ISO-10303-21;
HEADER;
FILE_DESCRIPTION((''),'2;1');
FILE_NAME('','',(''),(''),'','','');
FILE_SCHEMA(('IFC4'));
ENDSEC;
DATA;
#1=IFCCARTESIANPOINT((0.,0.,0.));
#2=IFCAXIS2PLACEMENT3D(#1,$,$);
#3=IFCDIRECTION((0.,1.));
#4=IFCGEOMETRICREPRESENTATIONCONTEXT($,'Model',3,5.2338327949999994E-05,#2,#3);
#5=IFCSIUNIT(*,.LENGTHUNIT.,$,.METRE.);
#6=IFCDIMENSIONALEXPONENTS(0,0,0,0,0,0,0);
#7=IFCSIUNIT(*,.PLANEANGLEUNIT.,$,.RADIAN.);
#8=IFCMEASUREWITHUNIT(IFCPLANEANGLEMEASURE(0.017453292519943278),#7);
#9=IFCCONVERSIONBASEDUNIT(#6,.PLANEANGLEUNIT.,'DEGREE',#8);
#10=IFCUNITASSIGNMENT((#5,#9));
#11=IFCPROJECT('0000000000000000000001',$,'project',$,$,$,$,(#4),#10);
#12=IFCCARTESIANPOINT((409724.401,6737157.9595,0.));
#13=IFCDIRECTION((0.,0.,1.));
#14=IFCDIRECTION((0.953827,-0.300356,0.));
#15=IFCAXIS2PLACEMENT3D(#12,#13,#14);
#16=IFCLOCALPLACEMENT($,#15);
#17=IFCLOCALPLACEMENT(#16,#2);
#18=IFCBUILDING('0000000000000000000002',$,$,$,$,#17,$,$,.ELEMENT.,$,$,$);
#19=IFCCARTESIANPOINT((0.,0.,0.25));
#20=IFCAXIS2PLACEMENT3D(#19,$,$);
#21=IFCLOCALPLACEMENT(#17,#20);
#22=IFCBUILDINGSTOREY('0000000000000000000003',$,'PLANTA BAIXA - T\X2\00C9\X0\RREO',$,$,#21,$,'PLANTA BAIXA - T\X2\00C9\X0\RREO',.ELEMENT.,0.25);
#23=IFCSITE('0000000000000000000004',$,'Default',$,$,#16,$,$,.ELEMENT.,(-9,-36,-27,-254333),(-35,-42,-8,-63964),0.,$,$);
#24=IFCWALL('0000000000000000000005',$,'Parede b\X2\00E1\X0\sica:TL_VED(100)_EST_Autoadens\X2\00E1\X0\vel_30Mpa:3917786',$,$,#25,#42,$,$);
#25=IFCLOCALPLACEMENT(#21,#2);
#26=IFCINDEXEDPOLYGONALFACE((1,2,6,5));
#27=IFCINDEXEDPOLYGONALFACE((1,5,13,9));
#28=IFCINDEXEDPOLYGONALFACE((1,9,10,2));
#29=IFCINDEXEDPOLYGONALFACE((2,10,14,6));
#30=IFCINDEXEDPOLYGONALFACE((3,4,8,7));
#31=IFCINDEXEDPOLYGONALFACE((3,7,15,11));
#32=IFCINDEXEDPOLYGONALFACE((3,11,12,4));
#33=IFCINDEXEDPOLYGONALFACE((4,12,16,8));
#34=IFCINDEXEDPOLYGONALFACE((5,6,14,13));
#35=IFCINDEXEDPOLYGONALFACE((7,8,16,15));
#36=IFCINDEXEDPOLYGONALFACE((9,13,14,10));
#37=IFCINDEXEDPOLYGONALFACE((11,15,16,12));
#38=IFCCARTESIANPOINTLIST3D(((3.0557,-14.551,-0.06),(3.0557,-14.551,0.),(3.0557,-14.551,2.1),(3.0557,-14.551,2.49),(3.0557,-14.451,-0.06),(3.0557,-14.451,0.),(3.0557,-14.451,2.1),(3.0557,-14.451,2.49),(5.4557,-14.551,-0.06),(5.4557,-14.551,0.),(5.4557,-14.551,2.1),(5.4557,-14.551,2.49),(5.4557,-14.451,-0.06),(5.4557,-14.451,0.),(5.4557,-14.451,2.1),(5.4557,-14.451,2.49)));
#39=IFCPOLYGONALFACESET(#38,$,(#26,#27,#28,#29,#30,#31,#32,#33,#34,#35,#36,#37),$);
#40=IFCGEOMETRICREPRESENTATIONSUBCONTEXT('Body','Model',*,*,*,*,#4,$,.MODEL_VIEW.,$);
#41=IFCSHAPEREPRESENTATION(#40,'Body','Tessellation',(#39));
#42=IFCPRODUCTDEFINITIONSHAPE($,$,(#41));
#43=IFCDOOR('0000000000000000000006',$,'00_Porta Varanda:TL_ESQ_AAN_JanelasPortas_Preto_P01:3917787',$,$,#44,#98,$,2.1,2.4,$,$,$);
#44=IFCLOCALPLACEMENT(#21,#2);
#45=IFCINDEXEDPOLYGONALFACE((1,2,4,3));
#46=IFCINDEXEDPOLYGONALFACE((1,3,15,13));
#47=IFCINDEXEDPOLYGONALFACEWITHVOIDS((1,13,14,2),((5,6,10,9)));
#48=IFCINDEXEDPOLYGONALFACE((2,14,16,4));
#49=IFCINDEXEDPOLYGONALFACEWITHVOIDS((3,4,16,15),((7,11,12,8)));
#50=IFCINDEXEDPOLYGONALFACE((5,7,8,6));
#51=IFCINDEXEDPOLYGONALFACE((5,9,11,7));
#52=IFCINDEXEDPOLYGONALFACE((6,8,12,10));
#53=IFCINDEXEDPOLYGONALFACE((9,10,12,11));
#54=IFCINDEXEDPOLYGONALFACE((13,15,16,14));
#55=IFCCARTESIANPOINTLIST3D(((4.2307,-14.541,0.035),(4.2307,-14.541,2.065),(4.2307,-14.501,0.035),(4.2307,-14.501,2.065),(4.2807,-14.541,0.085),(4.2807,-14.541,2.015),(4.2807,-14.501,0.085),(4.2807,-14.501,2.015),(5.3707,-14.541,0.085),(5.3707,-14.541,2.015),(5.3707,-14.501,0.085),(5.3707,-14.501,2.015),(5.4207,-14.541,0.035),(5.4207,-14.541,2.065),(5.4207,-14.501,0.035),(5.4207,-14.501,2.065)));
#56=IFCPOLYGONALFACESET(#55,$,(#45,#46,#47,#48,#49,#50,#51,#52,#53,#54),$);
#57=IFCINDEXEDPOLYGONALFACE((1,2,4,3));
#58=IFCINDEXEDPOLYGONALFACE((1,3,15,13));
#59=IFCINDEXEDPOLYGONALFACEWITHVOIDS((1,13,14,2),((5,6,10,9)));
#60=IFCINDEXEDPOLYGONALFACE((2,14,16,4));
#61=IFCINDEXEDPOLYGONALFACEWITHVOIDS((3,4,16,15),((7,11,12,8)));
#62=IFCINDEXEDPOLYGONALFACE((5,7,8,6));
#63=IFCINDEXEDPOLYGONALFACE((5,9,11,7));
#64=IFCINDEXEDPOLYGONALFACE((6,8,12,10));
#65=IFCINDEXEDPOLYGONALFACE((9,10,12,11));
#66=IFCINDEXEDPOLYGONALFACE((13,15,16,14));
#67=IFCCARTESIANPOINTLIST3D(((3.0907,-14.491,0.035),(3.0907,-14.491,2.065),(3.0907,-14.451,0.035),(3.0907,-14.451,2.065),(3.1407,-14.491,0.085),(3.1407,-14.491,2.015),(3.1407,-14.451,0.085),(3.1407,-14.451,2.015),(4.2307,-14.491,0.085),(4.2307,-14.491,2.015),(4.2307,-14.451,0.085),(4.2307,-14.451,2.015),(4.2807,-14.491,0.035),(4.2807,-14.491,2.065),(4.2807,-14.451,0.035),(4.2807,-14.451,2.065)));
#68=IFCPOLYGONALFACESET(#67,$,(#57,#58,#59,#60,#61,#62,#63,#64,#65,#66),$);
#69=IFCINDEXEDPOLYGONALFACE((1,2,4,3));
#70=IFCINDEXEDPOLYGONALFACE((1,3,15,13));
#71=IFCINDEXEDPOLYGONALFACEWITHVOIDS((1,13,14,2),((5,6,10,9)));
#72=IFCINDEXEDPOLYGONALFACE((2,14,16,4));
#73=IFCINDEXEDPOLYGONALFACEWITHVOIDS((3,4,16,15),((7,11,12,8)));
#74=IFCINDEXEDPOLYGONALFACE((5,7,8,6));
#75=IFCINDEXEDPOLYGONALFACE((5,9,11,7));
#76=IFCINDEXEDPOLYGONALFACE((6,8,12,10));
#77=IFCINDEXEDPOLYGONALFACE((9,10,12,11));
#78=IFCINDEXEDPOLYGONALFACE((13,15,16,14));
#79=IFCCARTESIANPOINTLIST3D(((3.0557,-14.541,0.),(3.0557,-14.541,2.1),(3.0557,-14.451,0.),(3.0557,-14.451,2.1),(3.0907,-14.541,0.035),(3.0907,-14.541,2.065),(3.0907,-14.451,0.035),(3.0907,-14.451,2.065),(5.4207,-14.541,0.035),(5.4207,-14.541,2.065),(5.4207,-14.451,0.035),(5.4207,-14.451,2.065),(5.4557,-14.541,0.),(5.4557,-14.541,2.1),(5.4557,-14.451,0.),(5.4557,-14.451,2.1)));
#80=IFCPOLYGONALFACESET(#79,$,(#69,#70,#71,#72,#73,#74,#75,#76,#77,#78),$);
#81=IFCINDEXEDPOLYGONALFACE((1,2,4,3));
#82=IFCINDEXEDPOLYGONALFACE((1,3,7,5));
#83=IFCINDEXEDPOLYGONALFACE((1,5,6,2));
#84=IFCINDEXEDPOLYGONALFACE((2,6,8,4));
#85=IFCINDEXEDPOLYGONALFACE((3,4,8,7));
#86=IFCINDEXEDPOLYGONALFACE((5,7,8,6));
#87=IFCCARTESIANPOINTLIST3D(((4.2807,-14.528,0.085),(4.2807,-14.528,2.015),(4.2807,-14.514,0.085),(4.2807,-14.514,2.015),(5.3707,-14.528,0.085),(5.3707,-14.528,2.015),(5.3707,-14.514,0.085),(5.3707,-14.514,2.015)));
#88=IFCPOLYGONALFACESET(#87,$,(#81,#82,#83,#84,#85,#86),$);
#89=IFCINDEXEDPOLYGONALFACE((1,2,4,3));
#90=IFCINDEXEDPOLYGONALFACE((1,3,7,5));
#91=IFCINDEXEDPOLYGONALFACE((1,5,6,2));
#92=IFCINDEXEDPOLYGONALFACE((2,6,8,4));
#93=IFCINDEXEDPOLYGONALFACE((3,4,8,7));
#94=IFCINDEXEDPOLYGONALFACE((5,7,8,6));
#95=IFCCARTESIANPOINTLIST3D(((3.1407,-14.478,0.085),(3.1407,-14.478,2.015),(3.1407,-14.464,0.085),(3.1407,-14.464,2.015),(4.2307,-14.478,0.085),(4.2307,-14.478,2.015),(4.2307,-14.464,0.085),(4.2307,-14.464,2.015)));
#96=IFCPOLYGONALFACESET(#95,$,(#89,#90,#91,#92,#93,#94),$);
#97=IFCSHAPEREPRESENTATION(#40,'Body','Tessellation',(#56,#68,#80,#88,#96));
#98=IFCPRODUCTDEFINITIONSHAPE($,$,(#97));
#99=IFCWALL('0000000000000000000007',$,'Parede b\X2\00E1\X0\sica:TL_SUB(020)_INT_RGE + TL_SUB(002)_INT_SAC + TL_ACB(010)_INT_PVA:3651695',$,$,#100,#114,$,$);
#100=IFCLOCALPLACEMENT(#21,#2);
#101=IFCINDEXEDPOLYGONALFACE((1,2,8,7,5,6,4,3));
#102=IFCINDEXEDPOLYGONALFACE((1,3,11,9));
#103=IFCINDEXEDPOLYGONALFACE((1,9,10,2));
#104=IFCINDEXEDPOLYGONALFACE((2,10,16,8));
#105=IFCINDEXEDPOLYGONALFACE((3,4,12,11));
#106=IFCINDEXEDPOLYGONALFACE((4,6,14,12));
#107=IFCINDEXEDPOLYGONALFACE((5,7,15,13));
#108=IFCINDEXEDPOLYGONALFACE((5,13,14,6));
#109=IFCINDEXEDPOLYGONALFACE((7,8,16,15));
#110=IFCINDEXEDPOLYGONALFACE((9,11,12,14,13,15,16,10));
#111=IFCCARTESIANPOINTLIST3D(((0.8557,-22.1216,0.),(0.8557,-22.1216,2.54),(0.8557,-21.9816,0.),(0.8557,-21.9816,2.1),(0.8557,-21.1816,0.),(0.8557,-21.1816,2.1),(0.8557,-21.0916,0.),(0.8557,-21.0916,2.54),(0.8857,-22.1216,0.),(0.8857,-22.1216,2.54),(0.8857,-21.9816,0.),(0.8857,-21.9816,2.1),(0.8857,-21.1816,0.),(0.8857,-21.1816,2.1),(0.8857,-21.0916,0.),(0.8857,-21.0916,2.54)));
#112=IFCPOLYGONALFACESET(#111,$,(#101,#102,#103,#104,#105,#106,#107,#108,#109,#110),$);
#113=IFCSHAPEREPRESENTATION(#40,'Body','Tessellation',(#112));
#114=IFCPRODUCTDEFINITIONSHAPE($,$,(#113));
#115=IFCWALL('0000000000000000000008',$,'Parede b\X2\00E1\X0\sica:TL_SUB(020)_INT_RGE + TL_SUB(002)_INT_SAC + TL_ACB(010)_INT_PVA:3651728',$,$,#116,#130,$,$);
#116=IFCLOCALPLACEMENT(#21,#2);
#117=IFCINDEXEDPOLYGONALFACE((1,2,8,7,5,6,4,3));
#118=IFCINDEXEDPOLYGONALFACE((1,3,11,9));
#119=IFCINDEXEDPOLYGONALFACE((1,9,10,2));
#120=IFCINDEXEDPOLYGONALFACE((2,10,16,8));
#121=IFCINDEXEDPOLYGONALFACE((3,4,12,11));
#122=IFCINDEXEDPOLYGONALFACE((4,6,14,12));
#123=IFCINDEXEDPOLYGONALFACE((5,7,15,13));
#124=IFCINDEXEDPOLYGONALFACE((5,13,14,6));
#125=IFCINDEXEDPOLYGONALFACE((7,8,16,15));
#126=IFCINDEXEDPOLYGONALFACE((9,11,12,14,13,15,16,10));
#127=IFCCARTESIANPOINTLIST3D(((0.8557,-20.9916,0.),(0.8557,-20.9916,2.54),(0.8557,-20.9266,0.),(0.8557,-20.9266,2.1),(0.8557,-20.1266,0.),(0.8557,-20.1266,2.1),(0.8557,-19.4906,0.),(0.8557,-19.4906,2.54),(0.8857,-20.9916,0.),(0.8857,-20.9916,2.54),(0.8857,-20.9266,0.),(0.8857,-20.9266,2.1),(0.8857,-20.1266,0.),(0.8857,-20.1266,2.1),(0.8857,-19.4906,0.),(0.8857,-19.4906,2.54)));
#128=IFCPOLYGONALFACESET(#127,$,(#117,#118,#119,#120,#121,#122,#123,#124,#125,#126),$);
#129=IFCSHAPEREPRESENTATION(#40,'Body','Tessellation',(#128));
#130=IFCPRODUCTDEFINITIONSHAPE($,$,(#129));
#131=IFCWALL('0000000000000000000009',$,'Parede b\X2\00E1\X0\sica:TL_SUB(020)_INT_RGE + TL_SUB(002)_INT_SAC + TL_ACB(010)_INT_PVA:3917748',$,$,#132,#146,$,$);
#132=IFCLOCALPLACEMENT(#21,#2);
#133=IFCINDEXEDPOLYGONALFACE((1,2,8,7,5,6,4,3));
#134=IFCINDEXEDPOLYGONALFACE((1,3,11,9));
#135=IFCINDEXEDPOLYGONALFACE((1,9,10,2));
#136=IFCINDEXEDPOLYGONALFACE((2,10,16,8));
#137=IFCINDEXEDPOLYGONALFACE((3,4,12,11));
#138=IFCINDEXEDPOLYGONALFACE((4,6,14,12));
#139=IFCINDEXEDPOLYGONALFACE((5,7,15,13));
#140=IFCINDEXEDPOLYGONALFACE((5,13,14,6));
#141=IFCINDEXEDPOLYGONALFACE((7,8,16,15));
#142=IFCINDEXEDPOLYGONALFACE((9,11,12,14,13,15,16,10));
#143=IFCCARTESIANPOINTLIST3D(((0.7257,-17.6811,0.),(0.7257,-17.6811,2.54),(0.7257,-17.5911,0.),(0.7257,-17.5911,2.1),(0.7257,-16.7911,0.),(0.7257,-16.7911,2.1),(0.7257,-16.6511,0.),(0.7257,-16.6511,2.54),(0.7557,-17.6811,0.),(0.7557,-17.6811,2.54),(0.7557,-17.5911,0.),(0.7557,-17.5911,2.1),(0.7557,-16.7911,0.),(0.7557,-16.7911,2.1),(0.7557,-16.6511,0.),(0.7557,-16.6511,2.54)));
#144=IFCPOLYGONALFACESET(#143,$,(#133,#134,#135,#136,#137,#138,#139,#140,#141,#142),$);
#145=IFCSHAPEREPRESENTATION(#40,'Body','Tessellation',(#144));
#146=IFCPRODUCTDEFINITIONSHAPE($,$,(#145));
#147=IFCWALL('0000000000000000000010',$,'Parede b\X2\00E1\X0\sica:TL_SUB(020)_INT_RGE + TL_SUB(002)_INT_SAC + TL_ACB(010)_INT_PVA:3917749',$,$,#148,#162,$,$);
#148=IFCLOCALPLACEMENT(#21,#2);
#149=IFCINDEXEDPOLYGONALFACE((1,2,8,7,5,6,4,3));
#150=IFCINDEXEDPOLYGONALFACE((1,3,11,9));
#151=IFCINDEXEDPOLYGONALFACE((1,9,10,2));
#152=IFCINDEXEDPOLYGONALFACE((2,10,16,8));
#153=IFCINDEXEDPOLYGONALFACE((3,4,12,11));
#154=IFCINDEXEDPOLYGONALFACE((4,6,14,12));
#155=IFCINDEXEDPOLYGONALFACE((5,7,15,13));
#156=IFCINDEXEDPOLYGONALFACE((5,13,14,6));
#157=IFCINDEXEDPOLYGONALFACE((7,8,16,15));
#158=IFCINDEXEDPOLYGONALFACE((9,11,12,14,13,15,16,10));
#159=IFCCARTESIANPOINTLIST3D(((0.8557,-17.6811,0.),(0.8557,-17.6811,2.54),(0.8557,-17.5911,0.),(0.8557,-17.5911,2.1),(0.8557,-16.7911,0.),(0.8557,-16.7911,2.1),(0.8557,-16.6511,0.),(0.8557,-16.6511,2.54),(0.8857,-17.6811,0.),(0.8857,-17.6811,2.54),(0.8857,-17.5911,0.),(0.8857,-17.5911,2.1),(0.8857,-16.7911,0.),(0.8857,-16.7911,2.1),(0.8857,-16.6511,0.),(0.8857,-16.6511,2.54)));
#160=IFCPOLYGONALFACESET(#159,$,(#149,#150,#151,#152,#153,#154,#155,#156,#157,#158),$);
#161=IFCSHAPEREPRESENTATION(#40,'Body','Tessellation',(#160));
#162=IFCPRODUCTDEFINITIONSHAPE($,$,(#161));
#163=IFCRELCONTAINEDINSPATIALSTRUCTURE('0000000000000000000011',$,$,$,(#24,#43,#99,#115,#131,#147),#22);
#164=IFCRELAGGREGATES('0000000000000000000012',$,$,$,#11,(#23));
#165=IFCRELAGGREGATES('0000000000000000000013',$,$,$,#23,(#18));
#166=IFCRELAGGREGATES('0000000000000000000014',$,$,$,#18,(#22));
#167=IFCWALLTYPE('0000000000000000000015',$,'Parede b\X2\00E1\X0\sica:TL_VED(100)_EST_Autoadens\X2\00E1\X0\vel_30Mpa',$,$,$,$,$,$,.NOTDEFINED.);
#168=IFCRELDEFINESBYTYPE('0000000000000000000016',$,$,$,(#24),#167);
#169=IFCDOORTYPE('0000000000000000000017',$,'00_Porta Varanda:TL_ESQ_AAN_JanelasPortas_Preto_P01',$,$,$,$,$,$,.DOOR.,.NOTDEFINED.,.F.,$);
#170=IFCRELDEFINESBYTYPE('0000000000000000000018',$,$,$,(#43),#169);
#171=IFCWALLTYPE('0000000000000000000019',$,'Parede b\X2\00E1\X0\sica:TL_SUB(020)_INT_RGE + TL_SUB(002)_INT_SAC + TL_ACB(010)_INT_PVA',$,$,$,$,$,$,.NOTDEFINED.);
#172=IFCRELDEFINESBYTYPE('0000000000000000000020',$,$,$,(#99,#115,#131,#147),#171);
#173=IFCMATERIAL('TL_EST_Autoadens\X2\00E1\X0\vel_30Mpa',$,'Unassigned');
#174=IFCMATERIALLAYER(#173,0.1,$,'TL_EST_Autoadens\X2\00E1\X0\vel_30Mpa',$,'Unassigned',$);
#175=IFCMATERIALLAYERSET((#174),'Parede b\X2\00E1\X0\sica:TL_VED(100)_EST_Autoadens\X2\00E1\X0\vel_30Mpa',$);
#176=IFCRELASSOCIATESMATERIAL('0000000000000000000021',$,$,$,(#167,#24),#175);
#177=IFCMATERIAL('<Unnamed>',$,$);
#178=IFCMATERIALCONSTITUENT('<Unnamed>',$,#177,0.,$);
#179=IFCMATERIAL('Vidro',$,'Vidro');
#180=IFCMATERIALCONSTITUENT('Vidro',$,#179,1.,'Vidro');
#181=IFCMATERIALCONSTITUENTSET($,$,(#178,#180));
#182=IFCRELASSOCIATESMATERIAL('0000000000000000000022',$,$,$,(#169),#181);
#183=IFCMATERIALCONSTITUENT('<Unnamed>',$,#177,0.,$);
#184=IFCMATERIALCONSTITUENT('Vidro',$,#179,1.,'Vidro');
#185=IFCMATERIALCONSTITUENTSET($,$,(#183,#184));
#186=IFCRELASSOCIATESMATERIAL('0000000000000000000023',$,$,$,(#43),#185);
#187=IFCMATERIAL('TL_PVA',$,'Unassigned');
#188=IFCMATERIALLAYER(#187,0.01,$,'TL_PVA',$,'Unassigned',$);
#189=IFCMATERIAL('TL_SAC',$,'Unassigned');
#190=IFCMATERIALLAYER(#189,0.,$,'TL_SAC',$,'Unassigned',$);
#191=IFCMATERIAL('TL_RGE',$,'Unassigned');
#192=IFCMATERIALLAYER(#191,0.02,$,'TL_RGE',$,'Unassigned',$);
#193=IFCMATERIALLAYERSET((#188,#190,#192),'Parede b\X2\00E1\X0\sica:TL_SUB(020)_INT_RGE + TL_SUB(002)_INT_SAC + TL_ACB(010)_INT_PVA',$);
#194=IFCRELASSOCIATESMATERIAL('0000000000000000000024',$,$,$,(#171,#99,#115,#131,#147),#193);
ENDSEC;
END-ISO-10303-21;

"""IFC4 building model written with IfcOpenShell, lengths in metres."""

from ifc_helpers import new_model, entity, si_unit, converted_unit, direction, frame, frame_2d, origin, place, context, subcontext, project, spatial, polyline, rectangle, outline, extrude, source, transform, mapped, material, layer, layer_set, layer_usage, constituent, constituent_set, type_object, type_shapes, element, fill, save


model = new_model("IFC4")

# Units and contexts
model_context = context("Model", 3, precision=5.2338327949999994e-05, world=origin(), true_north=direction((0.0, 1.0)))
body_context = subcontext(model_context, "Body", "Model", "MODEL_VIEW")
ifc_project = project(units=[si_unit("LENGTHUNIT", "METRE"), converted_unit("PLANEANGLEUNIT", "DEGREE", entity("IfcPlaneAngleMeasure", 0.017453292519943278), si_unit("PLANEANGLEUNIT", "RADIAN"), dimensions=[0, 0, 0, 0, 0, 0, 0])], contexts=[model_context])

# Site, building, storey
site_placement = place(None, frame((409724.401, 6737157.9595, 0.0), z_axis=(0.0, 0.0, 1.0), x_axis=(0.953827, -0.300356, 0.0)))
site = spatial("IfcSite", under=ifc_project, at=site_placement, Name="Default", CompositionType="ELEMENT", RefLatitude=(-9, -36, -27, -254333), RefLongitude=(-35, -42, -8, -63964), RefElevation=0.0)
building_placement = place(site_placement, origin())
building = spatial("IfcBuilding", under=site, at=building_placement, CompositionType="ELEMENT")
storey_placement = place(building_placement, frame((0.0, 0.0, 0.25)))
storey = spatial("IfcBuildingStorey", under=building, at=storey_placement, Name="PLANTA BAIXA - TÉRREO", LongName="PLANTA BAIXA - TÉRREO", CompositionType="ELEMENT", Elevation=0.25)

# Shared definitions
ifc_material_1 = material(Name="TL_EST_Autoadensável_30Mpa", Category="Unassigned")
ifc_layer_1 = layer(ifc_material_1, 0.1, Name="TL_EST_Autoadensável_30Mpa", Category="Unassigned")
ifc_layer_set_1 = layer_set([ifc_layer_1], Name="Parede básica:TL_VED(100)_EST_Autoadensável_30Mpa")
wall_type_1 = type_object("IfcWallType", Name="Parede básica:TL_VED(100)_EST_Autoadensável_30Mpa", PredefinedType="NOTDEFINED", material=ifc_layer_set_1)

# Wall, opening, door
ifc_layer_usage_1 = layer_usage(ifc_layer_set_1, "AXIS2", "NEGATIVE", 0.05)
wall_1_placement = place(storey_placement, frame((3.0557, -14.501, -0.06)))
wall_1 = element("IfcWall", 1, at=wall_1_placement, inside=storey, type_object=wall_type_1, material=ifc_layer_usage_1, Name="Parede básica:TL_VED(100)_EST_Autoadensável_30Mpa:3917786", context=body_context, shape_type="SweptSolid", body=[
    extrude(rectangle(XDim=2.4, YDim=0.1, at=frame_2d((1.2, 0.0), x_axis=(-1.0, 0.0))), origin(), (0.0, 0.0, 1.0), 2.55),
])
opening_1_placement = place(wall_1_placement, frame((2.4, 0.05, 0.06)))
opening_1 = element("IfcOpeningElement", 2, at=opening_1_placement, cuts=wall_1, PredefinedType="OPENING", context=body_context, shape_type="SweptSolid", body=[
    extrude(rectangle(XDim=2.1, YDim=2.4, at=frame_2d((1.05, 1.2), x_axis=(1.0, 0.0))), frame((0.0, 0.0, 0.0), z_axis=(0.0, -1.0, 0.0), x_axis=(0.0, 0.0, 1.0)), (0.0, 0.0, 1.0), 0.1),
])
ifc_material_2 = material(Name="<Unnamed>")
ifc_constituent_1 = constituent(ifc_material_2, Name="<Unnamed>", fraction=0.0)
ifc_material_3 = material(Name="Vidro", Category="Vidro")
ifc_constituent_2 = constituent(ifc_material_3, Name="Vidro", Category="Vidro", fraction=1.0)
ifc_constituent_set_1 = constituent_set(constituents=[ifc_constituent_1, ifc_constituent_2])
ifc_constituent_3 = constituent(ifc_material_2, Name="<Unnamed>", fraction=0.0)
ifc_constituent_4 = constituent(ifc_material_3, Name="Vidro", Category="Vidro", fraction=1.0)
ifc_constituent_set_2 = constituent_set(constituents=[ifc_constituent_3, ifc_constituent_4])
door_type = type_object("IfcDoorType", Name="00_Porta Varanda:TL_ESQ_AAN_JanelasPortas_Preto_P01", OperationType="NOTDEFINED", ParameterTakesPrecedence=False, PredefinedType="DOOR", material=ifc_constituent_set_2)
shared_shape = source(origin(), body_context, "Body", "SweptSolid", [
    extrude(outline(polyline([(-0.595, -1.015), (0.595, -1.015), (0.595, 1.015), (-0.595, 1.015), (-0.595, -1.015)]), holes=[polyline([(-0.545, 0.965), (0.545, 0.965), (0.545, -0.965), (-0.545, -0.965), (-0.545, 0.965)])]), frame((0.63, 0.09, 1.05), z_axis=(0.0, -1.0, 0.0), x_axis=(-1.0, 0.0, 0.0)), (0.0, 0.0, 1.0), 0.04),
    extrude(outline(polyline([(-0.595, -1.015), (0.595, -1.015), (0.595, 1.015), (-0.595, 1.015), (-0.595, -1.015)]), holes=[polyline([(-0.545, 0.965), (0.545, 0.965), (0.545, -0.965), (-0.545, -0.965), (-0.545, 0.965)])]), frame((1.77, 0.04, 1.05), z_axis=(0.0, -1.0, 0.0), x_axis=(1.0, 0.0, 0.0)), (0.0, 0.0, 1.0), 0.04),
    extrude(outline(polyline([(-1.2, -1.05), (1.2, -1.05), (1.2, 1.05), (-1.2, 1.05), (-1.2, -1.05)]), holes=[polyline([(-1.165, 1.015), (1.165, 1.015), (1.165, -1.015), (-1.165, -1.015), (-1.165, 1.015)])]), frame((1.2, 0.09, 1.05), z_axis=(0.0, -1.0, 0.0), x_axis=(1.0, 0.0, 0.0)), (0.0, 0.0, 1.0), 0.09),
    extrude(rectangle(XDim=1.09, YDim=0.014, at=frame_2d((0.0, 0.0), x_axis=(1.0, 0.0))), frame((0.63, 0.07, 0.085), z_axis=(0.0, 0.0, 1.0), x_axis=(-1.0, 0.0, 0.0)), (0.0, 0.0, 1.0), 1.93),
    extrude(rectangle(XDim=1.09, YDim=0.014, at=frame_2d((0.0, 0.0), x_axis=(1.0, 0.0))), frame((1.77, 0.02, 0.085), z_axis=(0.0, 0.0, 1.0), x_axis=(-1.0, 0.0, 0.0)), (0.0, 0.0, 1.0), 1.93),
])
type_shapes(door_type, [shared_shape])
door_placement = place(opening_1_placement, frame((0.0, 0.0, 0.0), z_axis=(0.0, 0.0, 1.0), x_axis=(-1.0, 0.0, 0.0)))
door = element("IfcDoor", 3, at=door_placement, inside=storey, type_object=door_type, material=ifc_constituent_set_1, Name="00_Porta Varanda:TL_ESQ_AAN_JanelasPortas_Preto_P01:3917787", OverallHeight=2.1, OverallWidth=2.4, context=body_context, shape_type="MappedRepresentation", body=[
    mapped(shared_shape, transform((0.0, 0.0, 0.0), scale=1.0)),
])
fill(opening_1, door)

# Walls, openings
ifc_material_4 = material(Name="TL_PVA", Category="Unassigned")
ifc_layer_2 = layer(ifc_material_4, 0.01, Name="TL_PVA", Category="Unassigned")
ifc_material_5 = material(Name="TL_SAC", Category="Unassigned")
ifc_layer_3 = layer(ifc_material_5, 0.0, Name="TL_SAC", Category="Unassigned")
ifc_material_6 = material(Name="TL_RGE", Category="Unassigned")
ifc_layer_4 = layer(ifc_material_6, 0.02, Name="TL_RGE", Category="Unassigned")
ifc_layer_set_2 = layer_set([ifc_layer_2, ifc_layer_3, ifc_layer_4], Name="Parede básica:TL_SUB(020)_INT_RGE + TL_SUB(002)_INT_SAC + TL_ACB(010)_INT_PVA")
ifc_layer_usage_2 = layer_usage(ifc_layer_set_2, "AXIS2", "NEGATIVE", 0.015)
wall_type_2 = type_object("IfcWallType", Name="Parede básica:TL_SUB(020)_INT_RGE + TL_SUB(002)_INT_SAC + TL_ACB(010)_INT_PVA", PredefinedType="NOTDEFINED", material=ifc_layer_set_2)
wall_2_placement = place(storey_placement, frame((0.8707, -21.0916, 0.0), z_axis=(0.0, 0.0, 1.0), x_axis=(0.0, -1.0, 0.0)))
wall_2 = element("IfcWall", 4, at=wall_2_placement, inside=storey, type_object=wall_type_2, material=ifc_layer_usage_2, Name="Parede básica:TL_SUB(020)_INT_RGE + TL_SUB(002)_INT_SAC + TL_ACB(010)_INT_PVA:3651695", context=body_context, shape_type="SweptSolid", body=[
    extrude(rectangle(XDim=1.03, YDim=0.03, at=frame_2d((0.515, 0.0), x_axis=(1.0, 0.0))), origin(), (0.0, 0.0, 1.0), 2.54),
])
opening_2_placement = place(wall_2_placement, frame((-21.0916, -0.8707, 0.0)))
element("IfcOpeningElement", 5, at=opening_2_placement, cuts=wall_2, PredefinedType="OPENING", context=body_context, shape_type="SweptSolid", body=[
    extrude(rectangle(XDim=2.1, YDim=0.8, at=frame_2d((0.0, 0.0), x_axis=(1.0, 0.0))), frame((21.5816, -0.6683, 1.05), z_axis=(0.0, 1.0, 0.0), x_axis=(0.0, 0.0, 1.0)), (0.0, 0.0, 1.0), 3.048),
])
ifc_layer_usage_3 = layer_usage(ifc_layer_set_2, "AXIS2", "POSITIVE", -0.015)
wall_3_placement = place(storey_placement, frame((0.8707, -20.9916, 0.0), z_axis=(0.0, 0.0, 1.0), x_axis=(0.0, 1.0, 0.0)))
wall_3 = element("IfcWall", 6, at=wall_3_placement, inside=storey, type_object=wall_type_2, material=ifc_layer_usage_3, Name="Parede básica:TL_SUB(020)_INT_RGE + TL_SUB(002)_INT_SAC + TL_ACB(010)_INT_PVA:3651728", context=body_context, shape_type="SweptSolid", body=[
    extrude(rectangle(XDim=1.501, YDim=0.03, at=frame_2d((0.7505, 0.0), x_axis=(-1.0, 0.0))), origin(), (0.0, 0.0, 1.0), 2.54),
])
opening_3_placement = place(wall_3_placement, frame((0.065, -0.015, 0.0)))
element("IfcOpeningElement", 7, at=opening_3_placement, cuts=wall_3, PredefinedType="OPENING", context=body_context, shape_type="SweptSolid", body=[
    extrude(rectangle(XDim=2.1, YDim=0.8, at=frame_2d((1.05, 0.4), x_axis=(1.0, 0.0))), frame((0.0, 0.0, 0.0), z_axis=(0.0, 1.0, 0.0), x_axis=(0.0, 0.0, 1.0)), (0.0, 0.0, 1.0), 0.03),
])
ifc_layer_usage_4 = layer_usage(ifc_layer_set_2, "AXIS2", "POSITIVE", -0.015)
wall_4_placement = place(storey_placement, frame((0.7407, -16.6511, 0.0), z_axis=(0.0, 0.0, 1.0), x_axis=(0.0, -1.0, 0.0)))
wall_4 = element("IfcWall", 8, at=wall_4_placement, inside=storey, type_object=wall_type_2, material=ifc_layer_usage_4, Name="Parede básica:TL_SUB(020)_INT_RGE + TL_SUB(002)_INT_SAC + TL_ACB(010)_INT_PVA:3917748", context=body_context, shape_type="SweptSolid", body=[
    extrude(rectangle(XDim=1.03, YDim=0.03, at=frame_2d((0.515, 0.0), x_axis=(1.0, 0.0))), origin(), (0.0, 0.0, 1.0), 2.54),
])
opening_4_placement = place(wall_4_placement, frame((-16.6511, -0.7407, 0.0)))
element("IfcOpeningElement", 9, at=opening_4_placement, cuts=wall_4, PredefinedType="OPENING", context=body_context, shape_type="SweptSolid", body=[
    extrude(rectangle(XDim=2.1, YDim=0.8, at=frame_2d((0.0, 0.0), x_axis=(0.0, 1.0))), frame((17.1911, -0.6683, 1.05), z_axis=(0.0, 1.0, 0.0), x_axis=(-1.0, 0.0, 0.0)), (0.0, 0.0, 1.0), 3.048),
])
ifc_layer_usage_5 = layer_usage(ifc_layer_set_2, "AXIS2", "POSITIVE", -0.015)
wall_5_placement = place(storey_placement, frame((0.8707, -17.6811, 0.0), z_axis=(0.0, 0.0, 1.0), x_axis=(0.0, 1.0, 0.0)))
wall_5 = element("IfcWall", 10, at=wall_5_placement, inside=storey, type_object=wall_type_2, material=ifc_layer_usage_5, Name="Parede básica:TL_SUB(020)_INT_RGE + TL_SUB(002)_INT_SAC + TL_ACB(010)_INT_PVA:3917749", context=body_context, shape_type="SweptSolid", body=[
    extrude(rectangle(XDim=1.03, YDim=0.03, at=frame_2d((0.515, 0.0), x_axis=(-1.0, 0.0))), origin(), (0.0, 0.0, 1.0), 2.54),
])
opening_5_placement = place(wall_5_placement, frame((17.6811, 0.8707, 0.0)))
element("IfcOpeningElement", 11, at=opening_5_placement, cuts=wall_5, PredefinedType="OPENING", context=body_context, shape_type="SweptSolid", body=[
    extrude(rectangle(XDim=2.1, YDim=0.8, at=frame_2d((0.0, 0.0), x_axis=(1.0, 0.0))), frame((-17.1911, -2.3797, 1.05), z_axis=(0.0, 1.0, 0.0), x_axis=(0.0, 0.0, 1.0)), (0.0, 0.0, 1.0), 3.048),
])

save(model, "model.ifc")
